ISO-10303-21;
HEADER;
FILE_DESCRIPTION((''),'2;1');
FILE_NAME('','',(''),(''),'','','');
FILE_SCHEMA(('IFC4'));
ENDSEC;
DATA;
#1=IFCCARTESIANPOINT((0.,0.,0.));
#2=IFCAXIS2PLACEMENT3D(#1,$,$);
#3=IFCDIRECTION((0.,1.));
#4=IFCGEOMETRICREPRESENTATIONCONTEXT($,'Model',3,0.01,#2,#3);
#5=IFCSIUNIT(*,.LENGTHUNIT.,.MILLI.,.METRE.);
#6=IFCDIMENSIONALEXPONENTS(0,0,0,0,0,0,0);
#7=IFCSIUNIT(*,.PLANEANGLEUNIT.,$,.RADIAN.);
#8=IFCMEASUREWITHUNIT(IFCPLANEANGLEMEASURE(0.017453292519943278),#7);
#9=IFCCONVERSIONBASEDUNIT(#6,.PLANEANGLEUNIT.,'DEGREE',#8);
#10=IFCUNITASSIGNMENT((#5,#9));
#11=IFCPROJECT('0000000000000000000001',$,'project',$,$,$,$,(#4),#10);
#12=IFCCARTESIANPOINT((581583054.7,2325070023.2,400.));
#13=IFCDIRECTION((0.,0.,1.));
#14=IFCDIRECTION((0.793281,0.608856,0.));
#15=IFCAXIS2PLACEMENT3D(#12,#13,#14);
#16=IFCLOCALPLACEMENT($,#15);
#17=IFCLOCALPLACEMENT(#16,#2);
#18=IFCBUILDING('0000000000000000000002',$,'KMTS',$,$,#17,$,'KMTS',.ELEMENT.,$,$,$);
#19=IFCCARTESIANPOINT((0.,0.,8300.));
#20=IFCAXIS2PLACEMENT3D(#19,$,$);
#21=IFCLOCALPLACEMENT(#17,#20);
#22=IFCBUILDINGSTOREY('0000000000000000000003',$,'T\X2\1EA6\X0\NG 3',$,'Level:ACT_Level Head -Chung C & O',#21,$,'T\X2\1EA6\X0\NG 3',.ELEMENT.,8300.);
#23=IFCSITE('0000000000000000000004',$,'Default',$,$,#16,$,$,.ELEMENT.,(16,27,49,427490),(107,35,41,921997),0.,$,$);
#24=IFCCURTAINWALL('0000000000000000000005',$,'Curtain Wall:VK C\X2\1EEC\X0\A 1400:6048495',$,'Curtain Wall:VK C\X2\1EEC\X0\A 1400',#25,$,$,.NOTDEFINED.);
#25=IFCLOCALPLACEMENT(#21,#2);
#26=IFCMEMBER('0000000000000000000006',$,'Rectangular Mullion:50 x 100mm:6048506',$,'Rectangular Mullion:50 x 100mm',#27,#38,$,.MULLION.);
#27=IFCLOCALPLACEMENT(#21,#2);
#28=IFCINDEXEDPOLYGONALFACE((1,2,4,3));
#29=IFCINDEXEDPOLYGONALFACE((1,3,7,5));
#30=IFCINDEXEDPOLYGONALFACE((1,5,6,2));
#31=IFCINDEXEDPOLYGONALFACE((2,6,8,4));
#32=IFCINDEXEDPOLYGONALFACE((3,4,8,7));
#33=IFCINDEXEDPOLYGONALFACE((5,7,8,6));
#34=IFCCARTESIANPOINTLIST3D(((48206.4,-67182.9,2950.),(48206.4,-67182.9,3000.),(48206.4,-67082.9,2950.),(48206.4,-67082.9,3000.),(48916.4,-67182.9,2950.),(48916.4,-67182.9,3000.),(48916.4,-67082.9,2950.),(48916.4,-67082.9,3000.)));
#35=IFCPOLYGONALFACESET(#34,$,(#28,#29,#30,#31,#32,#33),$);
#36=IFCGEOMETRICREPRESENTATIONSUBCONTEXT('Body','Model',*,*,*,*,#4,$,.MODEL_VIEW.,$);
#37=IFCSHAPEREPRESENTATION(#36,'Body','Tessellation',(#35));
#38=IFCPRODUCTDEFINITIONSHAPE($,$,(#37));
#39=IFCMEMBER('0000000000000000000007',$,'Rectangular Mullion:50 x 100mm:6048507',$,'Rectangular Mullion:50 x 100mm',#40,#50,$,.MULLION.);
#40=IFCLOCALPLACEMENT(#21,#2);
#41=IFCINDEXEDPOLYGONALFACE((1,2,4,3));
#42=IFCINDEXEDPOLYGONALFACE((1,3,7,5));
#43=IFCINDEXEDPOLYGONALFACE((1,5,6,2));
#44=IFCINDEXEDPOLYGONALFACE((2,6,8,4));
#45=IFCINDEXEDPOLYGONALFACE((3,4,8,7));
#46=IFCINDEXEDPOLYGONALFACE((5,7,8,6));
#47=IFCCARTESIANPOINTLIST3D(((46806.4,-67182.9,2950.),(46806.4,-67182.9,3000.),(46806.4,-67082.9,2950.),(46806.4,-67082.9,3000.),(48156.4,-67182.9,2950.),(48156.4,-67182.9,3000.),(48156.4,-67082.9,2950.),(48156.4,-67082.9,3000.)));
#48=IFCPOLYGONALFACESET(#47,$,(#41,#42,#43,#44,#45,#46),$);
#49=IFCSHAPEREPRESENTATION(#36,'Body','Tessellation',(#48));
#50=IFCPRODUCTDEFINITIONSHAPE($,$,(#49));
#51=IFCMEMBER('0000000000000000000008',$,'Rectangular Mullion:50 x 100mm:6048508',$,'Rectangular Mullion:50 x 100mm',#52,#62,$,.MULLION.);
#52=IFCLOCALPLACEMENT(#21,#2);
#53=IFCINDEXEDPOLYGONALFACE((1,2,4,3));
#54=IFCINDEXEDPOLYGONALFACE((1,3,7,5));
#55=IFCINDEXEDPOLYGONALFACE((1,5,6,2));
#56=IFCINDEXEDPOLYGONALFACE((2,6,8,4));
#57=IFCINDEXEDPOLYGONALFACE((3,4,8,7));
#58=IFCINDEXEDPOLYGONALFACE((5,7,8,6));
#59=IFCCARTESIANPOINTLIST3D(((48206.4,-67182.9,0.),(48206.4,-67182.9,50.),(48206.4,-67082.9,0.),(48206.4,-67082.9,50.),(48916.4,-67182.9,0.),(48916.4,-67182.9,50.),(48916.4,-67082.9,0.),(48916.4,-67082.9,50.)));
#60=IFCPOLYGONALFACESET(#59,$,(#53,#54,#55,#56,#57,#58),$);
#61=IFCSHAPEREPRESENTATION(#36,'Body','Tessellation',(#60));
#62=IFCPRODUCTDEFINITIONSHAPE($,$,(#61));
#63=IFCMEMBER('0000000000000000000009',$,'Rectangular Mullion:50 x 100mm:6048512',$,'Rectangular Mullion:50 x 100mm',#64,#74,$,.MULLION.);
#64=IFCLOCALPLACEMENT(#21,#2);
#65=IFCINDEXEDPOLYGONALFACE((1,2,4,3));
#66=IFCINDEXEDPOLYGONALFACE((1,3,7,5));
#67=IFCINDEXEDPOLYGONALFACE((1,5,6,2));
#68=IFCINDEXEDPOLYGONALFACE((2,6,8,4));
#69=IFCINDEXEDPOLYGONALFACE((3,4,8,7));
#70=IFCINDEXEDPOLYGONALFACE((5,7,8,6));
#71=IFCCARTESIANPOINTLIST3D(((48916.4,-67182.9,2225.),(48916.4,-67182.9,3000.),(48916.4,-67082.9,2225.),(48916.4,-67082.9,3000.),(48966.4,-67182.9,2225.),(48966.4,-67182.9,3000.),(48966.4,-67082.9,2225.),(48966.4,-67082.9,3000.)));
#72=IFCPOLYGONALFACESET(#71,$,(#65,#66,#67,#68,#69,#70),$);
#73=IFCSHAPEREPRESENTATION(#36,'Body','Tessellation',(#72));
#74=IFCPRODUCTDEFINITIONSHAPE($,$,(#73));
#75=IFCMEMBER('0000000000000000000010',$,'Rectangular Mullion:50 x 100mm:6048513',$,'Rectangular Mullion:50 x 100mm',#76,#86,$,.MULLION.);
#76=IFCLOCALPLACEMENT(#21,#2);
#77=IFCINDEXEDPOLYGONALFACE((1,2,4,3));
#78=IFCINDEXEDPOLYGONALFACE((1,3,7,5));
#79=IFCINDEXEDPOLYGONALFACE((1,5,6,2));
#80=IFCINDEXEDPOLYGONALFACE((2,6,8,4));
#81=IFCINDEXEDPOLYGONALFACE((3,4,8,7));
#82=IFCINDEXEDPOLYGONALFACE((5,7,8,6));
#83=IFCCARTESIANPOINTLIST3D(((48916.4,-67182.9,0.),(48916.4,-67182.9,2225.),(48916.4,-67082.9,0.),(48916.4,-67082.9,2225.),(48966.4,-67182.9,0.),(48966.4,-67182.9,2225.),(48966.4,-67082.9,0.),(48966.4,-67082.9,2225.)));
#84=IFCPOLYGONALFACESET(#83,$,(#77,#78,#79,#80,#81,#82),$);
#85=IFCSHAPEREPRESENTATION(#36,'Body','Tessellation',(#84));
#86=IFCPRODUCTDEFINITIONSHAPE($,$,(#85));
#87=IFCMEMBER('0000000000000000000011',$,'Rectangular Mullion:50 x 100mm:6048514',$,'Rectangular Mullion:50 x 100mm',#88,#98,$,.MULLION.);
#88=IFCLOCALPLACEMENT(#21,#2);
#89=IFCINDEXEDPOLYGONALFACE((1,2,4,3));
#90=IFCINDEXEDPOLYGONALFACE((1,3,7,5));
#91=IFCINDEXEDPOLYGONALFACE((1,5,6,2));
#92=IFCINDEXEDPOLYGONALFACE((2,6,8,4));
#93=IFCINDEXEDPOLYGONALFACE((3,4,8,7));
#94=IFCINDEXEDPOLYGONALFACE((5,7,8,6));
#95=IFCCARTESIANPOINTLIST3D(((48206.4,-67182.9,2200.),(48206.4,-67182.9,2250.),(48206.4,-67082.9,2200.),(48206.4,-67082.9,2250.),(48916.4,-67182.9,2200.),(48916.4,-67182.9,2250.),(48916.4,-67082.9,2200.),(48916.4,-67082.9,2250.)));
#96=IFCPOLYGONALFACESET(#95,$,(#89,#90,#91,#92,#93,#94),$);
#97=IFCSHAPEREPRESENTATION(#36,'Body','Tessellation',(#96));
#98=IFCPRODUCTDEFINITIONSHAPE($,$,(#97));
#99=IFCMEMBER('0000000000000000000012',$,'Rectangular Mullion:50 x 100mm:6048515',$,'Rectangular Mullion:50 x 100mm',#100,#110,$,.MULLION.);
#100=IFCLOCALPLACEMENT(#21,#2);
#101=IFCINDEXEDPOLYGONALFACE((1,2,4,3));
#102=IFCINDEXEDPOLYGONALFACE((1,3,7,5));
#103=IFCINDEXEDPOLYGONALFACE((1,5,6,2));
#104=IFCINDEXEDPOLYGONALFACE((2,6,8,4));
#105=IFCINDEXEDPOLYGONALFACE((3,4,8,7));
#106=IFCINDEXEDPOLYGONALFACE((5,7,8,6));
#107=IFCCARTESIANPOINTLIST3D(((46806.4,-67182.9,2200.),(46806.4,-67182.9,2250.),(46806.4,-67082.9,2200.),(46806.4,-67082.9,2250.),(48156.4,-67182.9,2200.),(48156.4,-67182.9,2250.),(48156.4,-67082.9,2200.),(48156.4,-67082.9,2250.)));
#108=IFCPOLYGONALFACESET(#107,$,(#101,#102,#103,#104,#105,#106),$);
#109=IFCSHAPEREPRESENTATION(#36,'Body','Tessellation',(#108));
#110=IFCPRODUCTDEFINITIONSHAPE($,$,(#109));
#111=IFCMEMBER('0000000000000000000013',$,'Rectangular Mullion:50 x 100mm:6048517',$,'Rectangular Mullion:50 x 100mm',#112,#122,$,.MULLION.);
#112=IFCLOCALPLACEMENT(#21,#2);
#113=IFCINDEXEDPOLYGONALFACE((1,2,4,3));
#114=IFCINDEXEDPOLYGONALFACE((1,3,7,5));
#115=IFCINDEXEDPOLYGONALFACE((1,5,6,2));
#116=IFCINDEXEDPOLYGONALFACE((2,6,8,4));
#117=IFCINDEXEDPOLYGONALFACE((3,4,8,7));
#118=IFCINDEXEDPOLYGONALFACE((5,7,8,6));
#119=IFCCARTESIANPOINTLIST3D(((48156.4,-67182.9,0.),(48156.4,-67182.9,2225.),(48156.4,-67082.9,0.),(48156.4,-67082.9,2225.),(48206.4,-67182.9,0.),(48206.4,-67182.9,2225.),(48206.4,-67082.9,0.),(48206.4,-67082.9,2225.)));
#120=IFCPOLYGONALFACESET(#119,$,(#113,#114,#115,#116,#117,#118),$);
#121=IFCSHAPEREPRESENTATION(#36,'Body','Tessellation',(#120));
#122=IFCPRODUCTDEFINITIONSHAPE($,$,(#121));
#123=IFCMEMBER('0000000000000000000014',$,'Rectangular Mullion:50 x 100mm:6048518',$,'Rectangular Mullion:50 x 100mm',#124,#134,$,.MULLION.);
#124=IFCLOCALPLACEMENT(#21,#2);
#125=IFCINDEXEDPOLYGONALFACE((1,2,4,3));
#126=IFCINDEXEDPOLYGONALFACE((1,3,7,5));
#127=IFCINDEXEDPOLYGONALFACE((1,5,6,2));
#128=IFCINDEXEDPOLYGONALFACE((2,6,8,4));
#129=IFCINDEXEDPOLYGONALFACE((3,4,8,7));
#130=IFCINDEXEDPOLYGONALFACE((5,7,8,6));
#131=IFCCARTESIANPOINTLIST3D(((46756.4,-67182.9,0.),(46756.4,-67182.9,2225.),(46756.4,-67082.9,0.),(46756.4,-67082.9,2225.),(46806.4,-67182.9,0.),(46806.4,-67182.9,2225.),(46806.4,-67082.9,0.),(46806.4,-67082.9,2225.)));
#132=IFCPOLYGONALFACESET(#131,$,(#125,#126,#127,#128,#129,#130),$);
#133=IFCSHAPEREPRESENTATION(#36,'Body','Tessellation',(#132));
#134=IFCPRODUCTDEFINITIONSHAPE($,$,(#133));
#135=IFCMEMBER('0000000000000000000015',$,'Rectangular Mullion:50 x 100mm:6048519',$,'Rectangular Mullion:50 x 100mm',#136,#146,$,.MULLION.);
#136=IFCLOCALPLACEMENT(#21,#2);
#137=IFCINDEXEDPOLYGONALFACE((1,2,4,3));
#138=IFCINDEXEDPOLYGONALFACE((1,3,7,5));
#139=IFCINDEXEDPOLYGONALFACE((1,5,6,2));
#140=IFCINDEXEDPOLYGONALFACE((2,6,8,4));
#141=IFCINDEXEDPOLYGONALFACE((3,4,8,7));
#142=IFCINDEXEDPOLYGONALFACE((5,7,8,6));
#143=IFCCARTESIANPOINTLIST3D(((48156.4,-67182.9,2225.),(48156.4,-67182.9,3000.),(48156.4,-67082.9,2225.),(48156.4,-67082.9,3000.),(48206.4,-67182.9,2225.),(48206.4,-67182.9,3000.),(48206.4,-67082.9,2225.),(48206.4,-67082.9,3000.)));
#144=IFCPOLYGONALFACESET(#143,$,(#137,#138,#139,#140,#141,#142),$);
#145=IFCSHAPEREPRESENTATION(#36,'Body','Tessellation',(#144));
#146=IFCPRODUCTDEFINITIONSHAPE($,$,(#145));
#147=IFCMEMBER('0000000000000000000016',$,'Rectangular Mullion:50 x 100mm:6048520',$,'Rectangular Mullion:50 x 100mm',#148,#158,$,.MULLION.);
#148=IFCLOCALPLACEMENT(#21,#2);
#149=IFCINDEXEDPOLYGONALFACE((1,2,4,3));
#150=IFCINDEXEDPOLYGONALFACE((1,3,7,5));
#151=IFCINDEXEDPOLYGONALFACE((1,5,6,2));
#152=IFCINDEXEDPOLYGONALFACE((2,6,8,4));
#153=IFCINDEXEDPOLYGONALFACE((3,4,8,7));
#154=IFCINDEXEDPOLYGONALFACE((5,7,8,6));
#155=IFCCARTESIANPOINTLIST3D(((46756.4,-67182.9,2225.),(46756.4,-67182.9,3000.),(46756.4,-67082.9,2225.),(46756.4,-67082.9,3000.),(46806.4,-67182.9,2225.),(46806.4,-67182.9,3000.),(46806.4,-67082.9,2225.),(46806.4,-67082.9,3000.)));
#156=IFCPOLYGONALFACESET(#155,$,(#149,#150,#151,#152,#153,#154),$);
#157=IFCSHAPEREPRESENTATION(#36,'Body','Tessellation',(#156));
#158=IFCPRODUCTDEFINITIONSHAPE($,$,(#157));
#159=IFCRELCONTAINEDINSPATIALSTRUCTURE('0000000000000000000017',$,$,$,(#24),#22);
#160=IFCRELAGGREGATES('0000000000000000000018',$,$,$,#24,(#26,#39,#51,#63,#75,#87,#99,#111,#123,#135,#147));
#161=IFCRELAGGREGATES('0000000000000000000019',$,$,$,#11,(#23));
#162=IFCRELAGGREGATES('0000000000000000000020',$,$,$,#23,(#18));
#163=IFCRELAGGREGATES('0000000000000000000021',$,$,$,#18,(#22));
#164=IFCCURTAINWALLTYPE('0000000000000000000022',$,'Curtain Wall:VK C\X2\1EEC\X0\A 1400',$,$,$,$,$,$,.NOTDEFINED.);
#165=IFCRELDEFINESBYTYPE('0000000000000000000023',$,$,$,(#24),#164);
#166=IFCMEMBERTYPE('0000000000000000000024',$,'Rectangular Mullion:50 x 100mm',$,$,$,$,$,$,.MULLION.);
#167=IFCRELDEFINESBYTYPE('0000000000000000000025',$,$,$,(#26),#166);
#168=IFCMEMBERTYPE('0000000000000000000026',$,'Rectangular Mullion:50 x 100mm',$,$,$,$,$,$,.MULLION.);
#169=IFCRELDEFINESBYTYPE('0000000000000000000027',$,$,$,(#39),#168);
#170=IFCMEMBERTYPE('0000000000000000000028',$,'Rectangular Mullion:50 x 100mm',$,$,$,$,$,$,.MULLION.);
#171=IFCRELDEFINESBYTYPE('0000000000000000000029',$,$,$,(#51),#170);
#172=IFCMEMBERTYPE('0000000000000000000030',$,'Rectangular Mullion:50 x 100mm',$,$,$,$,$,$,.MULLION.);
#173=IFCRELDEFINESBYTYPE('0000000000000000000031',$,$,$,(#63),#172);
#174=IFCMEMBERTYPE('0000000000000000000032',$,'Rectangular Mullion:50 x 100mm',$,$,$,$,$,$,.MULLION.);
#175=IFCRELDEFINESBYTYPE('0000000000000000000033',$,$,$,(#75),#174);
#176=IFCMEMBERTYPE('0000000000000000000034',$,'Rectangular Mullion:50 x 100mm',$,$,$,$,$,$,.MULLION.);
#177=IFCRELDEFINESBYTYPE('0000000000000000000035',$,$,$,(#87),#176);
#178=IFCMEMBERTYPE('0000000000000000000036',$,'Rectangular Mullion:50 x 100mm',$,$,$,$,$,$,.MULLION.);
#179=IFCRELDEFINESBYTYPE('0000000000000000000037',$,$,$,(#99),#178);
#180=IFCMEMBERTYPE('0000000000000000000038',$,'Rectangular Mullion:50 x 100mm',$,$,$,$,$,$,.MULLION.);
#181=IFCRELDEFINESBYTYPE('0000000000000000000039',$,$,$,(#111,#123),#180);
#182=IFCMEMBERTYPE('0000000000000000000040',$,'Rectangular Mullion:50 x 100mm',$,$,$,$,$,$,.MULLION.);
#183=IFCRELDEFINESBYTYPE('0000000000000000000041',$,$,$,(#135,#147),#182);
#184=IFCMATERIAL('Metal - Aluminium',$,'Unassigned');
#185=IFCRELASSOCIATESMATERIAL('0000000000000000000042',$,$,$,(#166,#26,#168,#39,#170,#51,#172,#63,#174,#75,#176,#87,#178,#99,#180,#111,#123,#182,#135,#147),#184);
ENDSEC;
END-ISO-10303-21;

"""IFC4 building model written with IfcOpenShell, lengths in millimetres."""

from ifc_helpers import new_model, entity, si_unit, converted_unit, direction, frame, origin, place, context, subcontext, project, spatial, indexed_curve, outline, extrude, source, transform, mapped, material, type_object, type_shapes, element, aggregate, save


model = new_model("IFC4")

# Units and contexts
model_context = context("Model", 3, precision=0.01, world=origin(), true_north=direction((0.0, 1.0)))
body_context = subcontext(model_context, "Body", "Model", "MODEL_VIEW")
ifc_project = project(units=[si_unit("LENGTHUNIT", "METRE", prefix="MILLI"), converted_unit("PLANEANGLEUNIT", "DEGREE", entity("IfcPlaneAngleMeasure", 0.017453292519943278), si_unit("PLANEANGLEUNIT", "RADIAN"), dimensions=[0, 0, 0, 0, 0, 0, 0])], contexts=[model_context])

# Site, building, storey
site_placement = place(None, frame((581583054.7, 2325070023.2, 400.0), z_axis=(0.0, 0.0, 1.0), x_axis=(0.793281, 0.608856, 0.0)))
site = spatial("IfcSite", under=ifc_project, at=site_placement, Name="Default", CompositionType="ELEMENT", RefLatitude=(16, 27, 49, 427490), RefLongitude=(107, 35, 41, 921997), RefElevation=0.0)
building_placement = place(site_placement, origin())
building = spatial("IfcBuilding", under=site, at=building_placement, Name="KMTS", LongName="KMTS", CompositionType="ELEMENT")
storey_placement = place(building_placement, frame((0.0, 0.0, 8300.0)))
storey = spatial("IfcBuildingStorey", under=building, at=storey_placement, Name="TẦNG 3", ObjectType="Level:ACT_Level Head -Chung C & O", LongName="TẦNG 3", CompositionType="ELEMENT", Elevation=8300.0)

# Curtain wall, members
curtain_wall_type = type_object("IfcCurtainWallType", Name="Curtain Wall:VK CỬA 1400", PredefinedType="NOTDEFINED")
curtain_wall_placement = place(storey_placement, frame((0.0, 0.0, -8300.0)))
curtain_wall = element("IfcCurtainWall", 1, at=curtain_wall_placement, inside=storey, type_object=curtain_wall_type, Name="Curtain Wall:VK CỬA 1400:6048495", ObjectType="Curtain Wall:VK CỬA 1400", PredefinedType="NOTDEFINED")
ifc_material_1 = material(Name="Metal - Aluminium", Category="Unassigned")
member_type_1 = type_object("IfcMemberType", Name="Rectangular Mullion:50 x 100mm", PredefinedType="MULLION", material=ifc_material_1)
shared_shape_1 = source(origin(), body_context, "Body", "SweptSolid", [
    extrude(outline(indexed_curve([(-25.0, -50.0), (25.0, -50.0), (25.0, 50.0), (-25.0, 50.0), (-25.0, -50.0)], self_intersect=False)), frame((-25.0, 0.0, -710.0), z_axis=(0.0, 0.0, 1.0), x_axis=(-1.0, 0.0, 0.0)), (0.0, 0.0, 1.0), 710.0),
])
type_shapes(member_type_1, [shared_shape_1])
member_1_placement = place(curtain_wall_placement, frame((48206.4, -67132.9, 11300.0), z_axis=(-1.0, 0.0, 0.0), x_axis=(0.0, 0.0, 1.0)))
member_1 = element("IfcMember", 2, at=member_1_placement, type_object=member_type_1, material=ifc_material_1, Name="Rectangular Mullion:50 x 100mm:6048506", ObjectType="Rectangular Mullion:50 x 100mm", PredefinedType="MULLION", context=body_context, shape_type="MappedRepresentation", body=[
    mapped(shared_shape_1, transform((0.0, 0.0, 0.0), scale=1.0)),
])
member_type_2 = type_object("IfcMemberType", Name="Rectangular Mullion:50 x 100mm", PredefinedType="MULLION", material=ifc_material_1)
shared_shape_2 = source(origin(), body_context, "Body", "SweptSolid", [
    extrude(outline(indexed_curve([(-25.0, -50.0), (25.0, -50.0), (25.0, 50.0), (-25.0, 50.0), (-25.0, -50.0)], self_intersect=False)), frame((-25.0, 0.0, -1350.0), z_axis=(0.0, 0.0, 1.0), x_axis=(-1.0, 0.0, 0.0)), (0.0, 0.0, 1.0), 1350.0),
])
type_shapes(member_type_2, [shared_shape_2])
member_2_placement = place(curtain_wall_placement, frame((46806.4, -67132.9, 11300.0), z_axis=(-1.0, 0.0, 0.0), x_axis=(0.0, 0.0, 1.0)))
member_2 = element("IfcMember", 3, at=member_2_placement, type_object=member_type_2, material=ifc_material_1, Name="Rectangular Mullion:50 x 100mm:6048507", ObjectType="Rectangular Mullion:50 x 100mm", PredefinedType="MULLION", context=body_context, shape_type="MappedRepresentation", body=[
    mapped(shared_shape_2, transform((0.0, 0.0, 0.0), scale=1.0)),
])
member_type_3 = type_object("IfcMemberType", Name="Rectangular Mullion:50 x 100mm", PredefinedType="MULLION", material=ifc_material_1)
shared_shape_3 = source(origin(), body_context, "Body", "SweptSolid", [
    extrude(outline(indexed_curve([(-25.0, -50.0), (25.0, -50.0), (25.0, 50.0), (-25.0, 50.0), (-25.0, -50.0)], self_intersect=False)), frame((-25.0, 0.0, -710.0), z_axis=(0.0, 0.0, 1.0), x_axis=(-1.0, 0.0, 0.0)), (0.0, 0.0, 1.0), 710.0),
])
type_shapes(member_type_3, [shared_shape_3])
member_3_placement = place(curtain_wall_placement, frame((48916.4, -67132.9, 8300.0), z_axis=(1.0, 0.0, 0.0), x_axis=(0.0, 0.0, -1.0)))
member_3 = element("IfcMember", 4, at=member_3_placement, type_object=member_type_3, material=ifc_material_1, Name="Rectangular Mullion:50 x 100mm:6048508", ObjectType="Rectangular Mullion:50 x 100mm", PredefinedType="MULLION", context=body_context, shape_type="MappedRepresentation", body=[
    mapped(shared_shape_3, transform((0.0, 0.0, 0.0), scale=1.0)),
])
member_type_4 = type_object("IfcMemberType", Name="Rectangular Mullion:50 x 100mm", PredefinedType="MULLION", material=ifc_material_1)
shared_shape_4 = source(origin(), body_context, "Body", "SweptSolid", [
    extrude(outline(indexed_curve([(-25.0, -50.0), (25.0, -50.0), (25.0, 50.0), (-25.0, 50.0), (-25.0, -50.0)], self_intersect=False)), frame((-25.0, 0.0, -775.0), z_axis=(0.0, 0.0, 1.0), x_axis=(-1.0, 0.0, 0.0)), (0.0, 0.0, 1.0), 775.0),
])
type_shapes(member_type_4, [shared_shape_4])
member_4_placement = place(curtain_wall_placement, frame((48966.4, -67132.9, 11300.0)))
member_4 = element("IfcMember", 5, at=member_4_placement, type_object=member_type_4, material=ifc_material_1, Name="Rectangular Mullion:50 x 100mm:6048512", ObjectType="Rectangular Mullion:50 x 100mm", PredefinedType="MULLION", context=body_context, shape_type="MappedRepresentation", body=[
    mapped(shared_shape_4, transform((0.0, 0.0, 0.0), scale=1.0)),
])
member_type_5 = type_object("IfcMemberType", Name="Rectangular Mullion:50 x 100mm", PredefinedType="MULLION", material=ifc_material_1)
shared_shape_5 = source(origin(), body_context, "Body", "SweptSolid", [
    extrude(outline(indexed_curve([(-25.0, -50.0), (25.0, -50.0), (25.0, 50.0), (-25.0, 50.0), (-25.0, -50.0)], self_intersect=False)), frame((-25.0, 0.0, -2225.0), z_axis=(0.0, 0.0, 1.0), x_axis=(-1.0, 0.0, 0.0)), (0.0, 0.0, 1.0), 2225.0),
])
type_shapes(member_type_5, [shared_shape_5])
member_5_placement = place(curtain_wall_placement, frame((48966.4, -67132.9, 10525.0)))
member_5 = element("IfcMember", 6, at=member_5_placement, type_object=member_type_5, material=ifc_material_1, Name="Rectangular Mullion:50 x 100mm:6048513", ObjectType="Rectangular Mullion:50 x 100mm", PredefinedType="MULLION", context=body_context, shape_type="MappedRepresentation", body=[
    mapped(shared_shape_5, transform((0.0, 0.0, 0.0), scale=1.0)),
])
member_type_6 = type_object("IfcMemberType", Name="Rectangular Mullion:50 x 100mm", PredefinedType="MULLION", material=ifc_material_1)
shared_shape_6 = source(origin(), body_context, "Body", "SweptSolid", [
    extrude(outline(indexed_curve([(-25.0, -50.0), (25.0, -50.0), (25.0, 50.0), (-25.0, 50.0), (-25.0, -50.0)], self_intersect=False)), frame((0.0, 0.0, -710.0), z_axis=(0.0, 0.0, 1.0), x_axis=(-1.0, 0.0, 0.0)), (0.0, 0.0, 1.0), 710.0),
])
type_shapes(member_type_6, [shared_shape_6])
member_6_placement = place(curtain_wall_placement, frame((48206.4, -67132.9, 10525.0), z_axis=(-1.0, 0.0, 0.0), x_axis=(0.0, 0.0, 1.0)))
member_6 = element("IfcMember", 7, at=member_6_placement, type_object=member_type_6, material=ifc_material_1, Name="Rectangular Mullion:50 x 100mm:6048514", ObjectType="Rectangular Mullion:50 x 100mm", PredefinedType="MULLION", context=body_context, shape_type="MappedRepresentation", body=[
    mapped(shared_shape_6, transform((0.0, 0.0, 0.0), scale=1.0)),
])
member_type_7 = type_object("IfcMemberType", Name="Rectangular Mullion:50 x 100mm", PredefinedType="MULLION", material=ifc_material_1)
shared_shape_7 = source(origin(), body_context, "Body", "SweptSolid", [
    extrude(outline(indexed_curve([(-25.0, -50.0), (25.0, -50.0), (25.0, 50.0), (-25.0, 50.0), (-25.0, -50.0)], self_intersect=False)), frame((0.0, 0.0, -1350.0), z_axis=(0.0, 0.0, 1.0), x_axis=(-1.0, 0.0, 0.0)), (0.0, 0.0, 1.0), 1350.0),
])
type_shapes(member_type_7, [shared_shape_7])
member_7_placement = place(curtain_wall_placement, frame((46806.4, -67132.9, 10525.0), z_axis=(-1.0, 0.0, 0.0), x_axis=(0.0, 0.0, 1.0)))
member_7 = element("IfcMember", 8, at=member_7_placement, type_object=member_type_7, material=ifc_material_1, Name="Rectangular Mullion:50 x 100mm:6048515", ObjectType="Rectangular Mullion:50 x 100mm", PredefinedType="MULLION", context=body_context, shape_type="MappedRepresentation", body=[
    mapped(shared_shape_7, transform((0.0, 0.0, 0.0), scale=1.0)),
])
member_type_8 = type_object("IfcMemberType", Name="Rectangular Mullion:50 x 100mm", PredefinedType="MULLION", material=ifc_material_1)
shared_shape_8 = source(origin(), body_context, "Body", "SweptSolid", [
    extrude(outline(indexed_curve([(-25.0, -50.0), (25.0, -50.0), (25.0, 50.0), (-25.0, 50.0), (-25.0, -50.0)], self_intersect=False)), frame((0.0, 0.0, -2225.0), z_axis=(0.0, 0.0, 1.0), x_axis=(-1.0, 0.0, 0.0)), (0.0, 0.0, 1.0), 2225.0),
])
type_shapes(member_type_8, [shared_shape_8])
member_8_placement = place(curtain_wall_placement, frame((48181.4, -67132.9, 8300.0), z_axis=(0.0, 0.0, -1.0), x_axis=(-1.0, 0.0, 0.0)))
member_8 = element("IfcMember", 9, at=member_8_placement, type_object=member_type_8, material=ifc_material_1, Name="Rectangular Mullion:50 x 100mm:6048517", ObjectType="Rectangular Mullion:50 x 100mm", PredefinedType="MULLION", context=body_context, shape_type="MappedRepresentation", body=[
    mapped(shared_shape_8, transform((0.0, 0.0, 0.0), scale=1.0)),
])
member_9_placement = place(curtain_wall_placement, frame((46781.4, -67132.9, 8300.0), z_axis=(0.0, 0.0, -1.0), x_axis=(-1.0, 0.0, 0.0)))
member_9 = element("IfcMember", 10, at=member_9_placement, type_object=member_type_8, material=ifc_material_1, Name="Rectangular Mullion:50 x 100mm:6048518", ObjectType="Rectangular Mullion:50 x 100mm", PredefinedType="MULLION", context=body_context, shape_type="MappedRepresentation", body=[
    mapped(shared_shape_8, transform((0.0, 0.0, 0.0), scale=1.0)),
])
member_type_9 = type_object("IfcMemberType", Name="Rectangular Mullion:50 x 100mm", PredefinedType="MULLION", material=ifc_material_1)
shared_shape_9 = source(origin(), body_context, "Body", "SweptSolid", [
    extrude(outline(indexed_curve([(-25.0, -50.0), (25.0, -50.0), (25.0, 50.0), (-25.0, 50.0), (-25.0, -50.0)], self_intersect=False)), frame((0.0, 0.0, -775.0), z_axis=(0.0, 0.0, 1.0), x_axis=(-1.0, 0.0, 0.0)), (0.0, 0.0, 1.0), 775.0),
])
type_shapes(member_type_9, [shared_shape_9])
member_10_placement = place(curtain_wall_placement, frame((48181.4, -67132.9, 10525.0), z_axis=(0.0, 0.0, -1.0), x_axis=(-1.0, 0.0, 0.0)))
member_10 = element("IfcMember", 11, at=member_10_placement, type_object=member_type_9, material=ifc_material_1, Name="Rectangular Mullion:50 x 100mm:6048519", ObjectType="Rectangular Mullion:50 x 100mm", PredefinedType="MULLION", context=body_context, shape_type="MappedRepresentation", body=[
    mapped(shared_shape_9, transform((0.0, 0.0, 0.0), scale=1.0)),
])
member_11_placement = place(curtain_wall_placement, frame((46781.4, -67132.9, 10525.0), z_axis=(0.0, 0.0, -1.0), x_axis=(-1.0, 0.0, 0.0)))
member_11 = element("IfcMember", 12, at=member_11_placement, type_object=member_type_9, material=ifc_material_1, Name="Rectangular Mullion:50 x 100mm:6048520", ObjectType="Rectangular Mullion:50 x 100mm", PredefinedType="MULLION", context=body_context, shape_type="MappedRepresentation", body=[
    mapped(shared_shape_9, transform((0.0, 0.0, 0.0), scale=1.0)),
])

aggregate(curtain_wall, [member_1, member_2, member_3, member_4, member_5, member_6, member_7, member_8, member_9, member_10, member_11])

save(model, "model.ifc")
